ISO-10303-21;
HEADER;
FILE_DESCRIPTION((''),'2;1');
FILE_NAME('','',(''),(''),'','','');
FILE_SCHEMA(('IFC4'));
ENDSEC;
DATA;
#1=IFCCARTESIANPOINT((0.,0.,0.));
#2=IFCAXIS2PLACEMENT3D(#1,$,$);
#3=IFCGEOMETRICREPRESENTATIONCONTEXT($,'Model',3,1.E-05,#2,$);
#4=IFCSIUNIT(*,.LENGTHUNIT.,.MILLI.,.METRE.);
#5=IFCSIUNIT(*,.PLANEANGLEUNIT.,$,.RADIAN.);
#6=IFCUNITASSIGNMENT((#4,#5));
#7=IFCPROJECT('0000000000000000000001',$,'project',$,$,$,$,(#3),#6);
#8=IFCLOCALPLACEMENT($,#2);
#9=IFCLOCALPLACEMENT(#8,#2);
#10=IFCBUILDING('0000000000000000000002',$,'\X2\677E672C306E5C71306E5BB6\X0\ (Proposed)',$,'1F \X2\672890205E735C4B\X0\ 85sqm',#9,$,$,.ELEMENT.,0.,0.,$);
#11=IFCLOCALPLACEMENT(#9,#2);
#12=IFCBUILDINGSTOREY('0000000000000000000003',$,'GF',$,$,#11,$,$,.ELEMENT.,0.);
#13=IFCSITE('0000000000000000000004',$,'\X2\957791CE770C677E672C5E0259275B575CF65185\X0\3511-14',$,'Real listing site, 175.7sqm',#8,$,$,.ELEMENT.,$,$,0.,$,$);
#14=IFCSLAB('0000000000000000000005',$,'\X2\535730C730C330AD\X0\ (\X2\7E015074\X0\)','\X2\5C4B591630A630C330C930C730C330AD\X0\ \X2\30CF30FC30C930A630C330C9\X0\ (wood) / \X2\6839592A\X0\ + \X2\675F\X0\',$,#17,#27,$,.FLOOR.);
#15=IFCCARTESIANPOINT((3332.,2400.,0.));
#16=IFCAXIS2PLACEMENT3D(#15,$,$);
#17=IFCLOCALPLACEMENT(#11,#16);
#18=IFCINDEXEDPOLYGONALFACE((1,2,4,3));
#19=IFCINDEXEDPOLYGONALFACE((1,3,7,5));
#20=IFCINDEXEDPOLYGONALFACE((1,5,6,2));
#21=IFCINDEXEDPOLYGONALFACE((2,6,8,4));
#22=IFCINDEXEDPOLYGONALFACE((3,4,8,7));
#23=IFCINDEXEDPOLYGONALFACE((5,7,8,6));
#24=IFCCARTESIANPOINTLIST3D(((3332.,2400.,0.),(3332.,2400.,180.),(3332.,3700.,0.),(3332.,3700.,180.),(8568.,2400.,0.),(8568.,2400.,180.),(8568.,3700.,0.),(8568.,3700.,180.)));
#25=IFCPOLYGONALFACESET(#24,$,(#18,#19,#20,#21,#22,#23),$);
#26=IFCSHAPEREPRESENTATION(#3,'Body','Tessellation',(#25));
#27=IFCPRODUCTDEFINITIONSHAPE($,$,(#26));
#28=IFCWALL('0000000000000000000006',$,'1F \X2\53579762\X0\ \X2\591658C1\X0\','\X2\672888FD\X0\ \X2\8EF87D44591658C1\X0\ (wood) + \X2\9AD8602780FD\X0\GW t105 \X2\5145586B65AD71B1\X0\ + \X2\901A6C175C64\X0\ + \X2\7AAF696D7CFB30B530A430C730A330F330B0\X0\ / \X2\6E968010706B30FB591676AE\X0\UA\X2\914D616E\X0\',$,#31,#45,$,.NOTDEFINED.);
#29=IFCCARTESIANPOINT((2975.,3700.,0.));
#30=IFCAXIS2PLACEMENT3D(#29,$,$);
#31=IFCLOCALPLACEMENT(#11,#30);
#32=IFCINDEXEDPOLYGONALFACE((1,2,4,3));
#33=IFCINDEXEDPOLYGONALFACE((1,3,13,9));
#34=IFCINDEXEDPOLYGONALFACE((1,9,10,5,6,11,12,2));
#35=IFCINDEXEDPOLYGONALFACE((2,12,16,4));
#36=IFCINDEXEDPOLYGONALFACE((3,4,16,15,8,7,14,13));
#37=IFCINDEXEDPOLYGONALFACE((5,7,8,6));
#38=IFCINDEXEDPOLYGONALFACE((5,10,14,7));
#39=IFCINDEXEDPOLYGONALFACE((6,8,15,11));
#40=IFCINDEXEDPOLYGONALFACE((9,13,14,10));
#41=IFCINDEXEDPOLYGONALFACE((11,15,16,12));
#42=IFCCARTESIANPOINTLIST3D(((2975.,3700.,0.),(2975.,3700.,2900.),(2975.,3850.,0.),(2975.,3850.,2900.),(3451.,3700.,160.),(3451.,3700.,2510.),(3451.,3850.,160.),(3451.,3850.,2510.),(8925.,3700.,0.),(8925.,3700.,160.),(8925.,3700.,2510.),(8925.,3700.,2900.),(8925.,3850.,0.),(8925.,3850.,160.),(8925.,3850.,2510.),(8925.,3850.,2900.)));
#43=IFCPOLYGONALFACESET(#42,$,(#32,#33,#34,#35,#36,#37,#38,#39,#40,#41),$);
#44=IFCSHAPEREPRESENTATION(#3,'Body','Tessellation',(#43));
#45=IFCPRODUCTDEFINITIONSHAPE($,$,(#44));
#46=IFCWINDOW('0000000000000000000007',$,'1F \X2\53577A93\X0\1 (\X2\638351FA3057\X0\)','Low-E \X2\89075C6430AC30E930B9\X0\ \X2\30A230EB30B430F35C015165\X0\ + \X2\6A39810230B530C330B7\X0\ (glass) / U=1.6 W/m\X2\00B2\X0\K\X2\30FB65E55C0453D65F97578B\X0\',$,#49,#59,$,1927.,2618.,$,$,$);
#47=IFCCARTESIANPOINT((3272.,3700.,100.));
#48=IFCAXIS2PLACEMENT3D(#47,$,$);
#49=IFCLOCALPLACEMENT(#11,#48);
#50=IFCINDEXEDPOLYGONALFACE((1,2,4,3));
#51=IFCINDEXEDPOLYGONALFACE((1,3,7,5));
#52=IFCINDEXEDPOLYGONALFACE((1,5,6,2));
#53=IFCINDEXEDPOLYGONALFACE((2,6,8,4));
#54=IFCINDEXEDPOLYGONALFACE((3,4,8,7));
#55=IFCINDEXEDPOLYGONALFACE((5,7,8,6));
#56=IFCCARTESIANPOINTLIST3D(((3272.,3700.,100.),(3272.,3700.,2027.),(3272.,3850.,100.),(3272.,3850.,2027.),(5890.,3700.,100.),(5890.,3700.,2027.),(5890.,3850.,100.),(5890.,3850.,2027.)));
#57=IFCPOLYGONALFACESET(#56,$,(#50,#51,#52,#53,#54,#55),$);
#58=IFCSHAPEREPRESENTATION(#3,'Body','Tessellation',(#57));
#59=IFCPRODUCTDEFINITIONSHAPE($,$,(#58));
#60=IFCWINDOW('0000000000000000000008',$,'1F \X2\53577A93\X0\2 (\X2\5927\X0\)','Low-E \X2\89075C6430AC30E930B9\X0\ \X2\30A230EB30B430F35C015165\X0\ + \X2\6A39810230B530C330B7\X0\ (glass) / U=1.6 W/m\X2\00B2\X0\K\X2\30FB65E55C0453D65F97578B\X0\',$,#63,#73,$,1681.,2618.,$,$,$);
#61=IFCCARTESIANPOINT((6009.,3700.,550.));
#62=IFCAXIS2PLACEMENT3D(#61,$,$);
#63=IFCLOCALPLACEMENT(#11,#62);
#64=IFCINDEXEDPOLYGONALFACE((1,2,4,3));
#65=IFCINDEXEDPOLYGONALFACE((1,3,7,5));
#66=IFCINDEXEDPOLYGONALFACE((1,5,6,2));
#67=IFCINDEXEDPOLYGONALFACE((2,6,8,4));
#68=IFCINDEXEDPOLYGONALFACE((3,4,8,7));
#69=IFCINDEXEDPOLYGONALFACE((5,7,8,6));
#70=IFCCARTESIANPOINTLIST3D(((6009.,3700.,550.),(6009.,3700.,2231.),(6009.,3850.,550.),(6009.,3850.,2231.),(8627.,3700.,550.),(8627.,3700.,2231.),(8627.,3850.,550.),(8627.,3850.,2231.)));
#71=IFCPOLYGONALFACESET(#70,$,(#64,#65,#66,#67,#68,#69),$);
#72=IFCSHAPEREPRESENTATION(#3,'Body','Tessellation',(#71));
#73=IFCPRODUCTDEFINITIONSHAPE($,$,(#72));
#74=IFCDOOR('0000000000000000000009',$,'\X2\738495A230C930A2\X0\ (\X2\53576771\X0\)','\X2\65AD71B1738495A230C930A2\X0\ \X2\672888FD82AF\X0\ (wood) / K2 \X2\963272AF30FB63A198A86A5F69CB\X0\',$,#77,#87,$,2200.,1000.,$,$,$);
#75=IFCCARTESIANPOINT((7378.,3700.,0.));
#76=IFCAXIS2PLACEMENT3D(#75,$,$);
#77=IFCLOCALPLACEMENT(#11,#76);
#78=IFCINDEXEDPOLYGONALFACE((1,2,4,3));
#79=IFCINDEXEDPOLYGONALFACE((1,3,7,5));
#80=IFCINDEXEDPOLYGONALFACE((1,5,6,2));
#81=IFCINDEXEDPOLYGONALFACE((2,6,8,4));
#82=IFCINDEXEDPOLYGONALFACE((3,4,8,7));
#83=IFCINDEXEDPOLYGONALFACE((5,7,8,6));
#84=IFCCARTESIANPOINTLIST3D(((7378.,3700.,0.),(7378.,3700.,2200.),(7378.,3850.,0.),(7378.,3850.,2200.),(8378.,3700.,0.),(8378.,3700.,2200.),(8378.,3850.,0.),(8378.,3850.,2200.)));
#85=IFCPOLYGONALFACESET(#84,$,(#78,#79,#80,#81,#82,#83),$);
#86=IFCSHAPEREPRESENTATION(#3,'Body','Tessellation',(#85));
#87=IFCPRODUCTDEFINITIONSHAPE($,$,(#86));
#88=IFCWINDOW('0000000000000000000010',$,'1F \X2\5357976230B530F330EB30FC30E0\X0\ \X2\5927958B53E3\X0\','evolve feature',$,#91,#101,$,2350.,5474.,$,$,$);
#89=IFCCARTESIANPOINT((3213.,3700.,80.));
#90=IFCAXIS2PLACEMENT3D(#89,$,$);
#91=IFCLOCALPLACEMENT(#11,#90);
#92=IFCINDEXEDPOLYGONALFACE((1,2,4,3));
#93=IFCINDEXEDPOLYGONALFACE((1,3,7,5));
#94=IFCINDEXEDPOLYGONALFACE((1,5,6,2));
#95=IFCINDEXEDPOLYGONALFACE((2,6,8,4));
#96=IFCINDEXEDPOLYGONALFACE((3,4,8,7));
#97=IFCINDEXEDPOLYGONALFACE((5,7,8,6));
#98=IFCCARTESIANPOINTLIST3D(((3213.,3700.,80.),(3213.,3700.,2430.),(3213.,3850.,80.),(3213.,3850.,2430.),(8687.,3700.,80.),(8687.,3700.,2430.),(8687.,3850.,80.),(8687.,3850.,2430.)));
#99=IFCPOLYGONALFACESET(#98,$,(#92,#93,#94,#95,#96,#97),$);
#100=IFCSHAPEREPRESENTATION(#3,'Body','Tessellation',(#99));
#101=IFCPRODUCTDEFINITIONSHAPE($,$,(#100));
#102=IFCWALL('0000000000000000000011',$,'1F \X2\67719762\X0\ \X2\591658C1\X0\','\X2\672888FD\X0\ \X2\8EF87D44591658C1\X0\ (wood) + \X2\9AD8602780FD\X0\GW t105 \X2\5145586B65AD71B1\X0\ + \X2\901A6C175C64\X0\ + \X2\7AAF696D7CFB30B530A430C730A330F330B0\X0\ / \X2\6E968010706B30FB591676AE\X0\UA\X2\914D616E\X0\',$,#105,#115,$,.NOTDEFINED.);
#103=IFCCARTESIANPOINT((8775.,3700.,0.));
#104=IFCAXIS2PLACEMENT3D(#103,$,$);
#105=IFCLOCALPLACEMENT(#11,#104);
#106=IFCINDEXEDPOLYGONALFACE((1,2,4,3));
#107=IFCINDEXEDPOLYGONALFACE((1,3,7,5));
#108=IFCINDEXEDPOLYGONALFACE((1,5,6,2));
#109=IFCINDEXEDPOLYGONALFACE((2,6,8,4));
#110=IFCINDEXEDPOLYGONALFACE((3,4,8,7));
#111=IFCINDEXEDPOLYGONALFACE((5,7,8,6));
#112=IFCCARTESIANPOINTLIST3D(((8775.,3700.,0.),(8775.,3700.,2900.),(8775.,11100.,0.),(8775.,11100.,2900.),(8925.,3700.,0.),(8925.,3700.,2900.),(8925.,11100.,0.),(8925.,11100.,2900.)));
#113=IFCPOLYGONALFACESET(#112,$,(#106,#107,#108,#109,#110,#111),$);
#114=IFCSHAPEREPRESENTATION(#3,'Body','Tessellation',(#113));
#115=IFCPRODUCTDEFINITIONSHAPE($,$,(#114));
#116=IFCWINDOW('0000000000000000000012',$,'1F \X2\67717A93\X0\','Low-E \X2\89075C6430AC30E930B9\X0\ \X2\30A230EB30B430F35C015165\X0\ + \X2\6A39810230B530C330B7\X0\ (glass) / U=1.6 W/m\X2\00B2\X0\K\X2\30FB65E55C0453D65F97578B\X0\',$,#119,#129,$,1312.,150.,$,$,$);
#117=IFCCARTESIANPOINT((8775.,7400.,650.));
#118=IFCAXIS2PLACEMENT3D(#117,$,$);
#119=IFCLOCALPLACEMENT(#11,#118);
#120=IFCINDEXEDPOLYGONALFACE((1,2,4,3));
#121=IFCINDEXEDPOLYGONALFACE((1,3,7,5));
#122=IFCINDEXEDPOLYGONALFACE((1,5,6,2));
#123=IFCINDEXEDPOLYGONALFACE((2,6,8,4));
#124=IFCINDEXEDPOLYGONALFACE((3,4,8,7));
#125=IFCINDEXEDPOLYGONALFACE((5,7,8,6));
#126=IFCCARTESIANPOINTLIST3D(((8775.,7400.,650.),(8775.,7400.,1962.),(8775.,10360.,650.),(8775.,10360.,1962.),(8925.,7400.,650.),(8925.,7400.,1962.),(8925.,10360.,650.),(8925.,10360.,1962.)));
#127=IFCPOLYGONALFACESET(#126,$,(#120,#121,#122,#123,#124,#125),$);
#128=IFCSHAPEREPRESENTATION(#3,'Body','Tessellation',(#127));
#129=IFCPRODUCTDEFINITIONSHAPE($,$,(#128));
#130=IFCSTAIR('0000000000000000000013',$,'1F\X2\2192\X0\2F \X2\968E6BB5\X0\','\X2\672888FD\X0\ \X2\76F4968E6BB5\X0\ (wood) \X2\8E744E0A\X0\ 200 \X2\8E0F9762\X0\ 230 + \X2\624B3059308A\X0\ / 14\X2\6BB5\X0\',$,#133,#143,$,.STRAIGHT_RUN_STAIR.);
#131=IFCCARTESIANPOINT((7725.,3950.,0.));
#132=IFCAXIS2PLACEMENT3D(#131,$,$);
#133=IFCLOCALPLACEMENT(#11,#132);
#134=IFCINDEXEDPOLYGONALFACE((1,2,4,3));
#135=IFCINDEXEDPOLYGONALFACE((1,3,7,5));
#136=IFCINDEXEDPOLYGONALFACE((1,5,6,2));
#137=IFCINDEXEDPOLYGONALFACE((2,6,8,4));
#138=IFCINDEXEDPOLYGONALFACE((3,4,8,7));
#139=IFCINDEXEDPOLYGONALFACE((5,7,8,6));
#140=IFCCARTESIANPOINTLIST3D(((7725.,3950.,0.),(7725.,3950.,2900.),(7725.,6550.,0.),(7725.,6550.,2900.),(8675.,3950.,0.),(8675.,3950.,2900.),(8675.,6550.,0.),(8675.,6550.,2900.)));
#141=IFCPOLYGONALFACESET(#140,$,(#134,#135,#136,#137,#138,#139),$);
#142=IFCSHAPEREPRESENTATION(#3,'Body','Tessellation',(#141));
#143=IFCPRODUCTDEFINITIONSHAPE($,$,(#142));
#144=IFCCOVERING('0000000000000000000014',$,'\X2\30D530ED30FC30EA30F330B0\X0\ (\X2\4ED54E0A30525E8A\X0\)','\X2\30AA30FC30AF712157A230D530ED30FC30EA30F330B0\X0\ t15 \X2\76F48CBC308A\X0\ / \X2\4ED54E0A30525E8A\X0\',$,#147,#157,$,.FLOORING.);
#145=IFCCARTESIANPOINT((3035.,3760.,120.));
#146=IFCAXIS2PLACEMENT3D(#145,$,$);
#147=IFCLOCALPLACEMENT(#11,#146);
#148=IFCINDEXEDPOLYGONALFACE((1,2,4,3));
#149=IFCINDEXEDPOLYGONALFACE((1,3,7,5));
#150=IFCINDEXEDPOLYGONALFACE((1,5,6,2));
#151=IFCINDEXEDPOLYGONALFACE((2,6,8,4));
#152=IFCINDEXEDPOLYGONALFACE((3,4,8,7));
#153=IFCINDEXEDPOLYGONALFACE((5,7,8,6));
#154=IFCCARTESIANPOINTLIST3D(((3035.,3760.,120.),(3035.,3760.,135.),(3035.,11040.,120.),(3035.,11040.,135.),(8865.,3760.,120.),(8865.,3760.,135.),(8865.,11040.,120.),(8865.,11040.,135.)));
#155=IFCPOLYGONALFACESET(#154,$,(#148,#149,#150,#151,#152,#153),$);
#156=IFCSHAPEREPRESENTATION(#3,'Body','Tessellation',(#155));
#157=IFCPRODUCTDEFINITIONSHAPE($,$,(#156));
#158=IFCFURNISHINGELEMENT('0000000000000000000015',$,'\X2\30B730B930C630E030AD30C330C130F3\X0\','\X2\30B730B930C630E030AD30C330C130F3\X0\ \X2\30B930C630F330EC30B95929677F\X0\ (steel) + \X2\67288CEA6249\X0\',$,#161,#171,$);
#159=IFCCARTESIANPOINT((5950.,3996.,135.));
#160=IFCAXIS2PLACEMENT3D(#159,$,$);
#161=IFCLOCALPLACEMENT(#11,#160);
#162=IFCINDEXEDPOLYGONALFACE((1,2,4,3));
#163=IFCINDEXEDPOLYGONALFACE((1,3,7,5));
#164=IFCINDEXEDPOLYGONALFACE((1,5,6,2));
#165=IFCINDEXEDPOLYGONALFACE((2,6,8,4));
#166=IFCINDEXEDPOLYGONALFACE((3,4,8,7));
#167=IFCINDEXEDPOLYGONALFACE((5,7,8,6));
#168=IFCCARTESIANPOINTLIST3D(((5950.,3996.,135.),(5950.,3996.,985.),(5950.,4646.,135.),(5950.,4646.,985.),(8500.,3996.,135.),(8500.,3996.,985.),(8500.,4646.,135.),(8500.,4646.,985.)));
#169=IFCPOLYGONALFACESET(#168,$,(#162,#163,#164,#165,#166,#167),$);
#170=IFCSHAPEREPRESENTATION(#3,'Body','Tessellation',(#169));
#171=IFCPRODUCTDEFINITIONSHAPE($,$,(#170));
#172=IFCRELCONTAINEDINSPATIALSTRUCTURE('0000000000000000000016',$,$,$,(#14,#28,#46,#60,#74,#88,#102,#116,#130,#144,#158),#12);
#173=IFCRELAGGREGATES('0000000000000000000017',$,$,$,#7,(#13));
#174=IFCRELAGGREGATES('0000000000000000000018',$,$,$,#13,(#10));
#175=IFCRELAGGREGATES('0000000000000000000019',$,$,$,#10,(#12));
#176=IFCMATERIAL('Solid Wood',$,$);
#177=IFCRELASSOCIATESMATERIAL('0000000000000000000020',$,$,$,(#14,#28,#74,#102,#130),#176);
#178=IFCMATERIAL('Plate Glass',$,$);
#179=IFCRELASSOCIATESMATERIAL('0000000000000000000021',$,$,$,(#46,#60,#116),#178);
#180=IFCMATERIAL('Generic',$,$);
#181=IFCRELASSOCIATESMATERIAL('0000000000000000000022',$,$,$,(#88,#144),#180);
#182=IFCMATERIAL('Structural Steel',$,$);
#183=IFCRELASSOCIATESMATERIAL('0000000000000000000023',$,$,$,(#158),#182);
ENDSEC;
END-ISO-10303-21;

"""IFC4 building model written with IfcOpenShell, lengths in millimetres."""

from ifc_helpers import new_model, si_unit, frame, frame_2d, origin, place, context, project, spatial, rectangle, extrude, material, element, fill, save


model = new_model("IFC4")

# Units and contexts
model_context = context("Model", 3, precision=1e-05, world=origin())
ifc_project = project(units=[si_unit("LENGTHUNIT", "METRE", prefix="MILLI"), si_unit("PLANEANGLEUNIT", "RADIAN")], contexts=[model_context])

# Site, building, storey
site_placement = place(None, origin())
site = spatial("IfcSite", under=ifc_project, at=site_placement, Name="長野県松本市大字島内3511-14", ObjectType="Real listing site, 175.7sqm", CompositionType="ELEMENT", RefElevation=0.0)
building_placement = place(site_placement, origin())
building = spatial("IfcBuilding", under=site, at=building_placement, Name="松本の山の家 (Proposed)", ObjectType="1F 木造平屋 85sqm", CompositionType="ELEMENT", ElevationOfRefHeight=0.0, ElevationOfTerrain=0.0)
storey_placement = place(building_placement, origin())
storey = spatial("IfcBuildingStorey", under=building, at=storey_placement, Name="GF", CompositionType="ELEMENT", Elevation=0.0)

# Slab
ifc_material_1 = material(Name="Solid Wood")
slab_1_placement = place(storey_placement, frame((3332.0, 2400.0, 0.0)))
element("IfcSlab", 1, at=slab_1_placement, inside=storey, material=ifc_material_1, Name="南デッキ (縁側)", Description="屋外ウッドデッキ ハードウッド (wood) / 根太 + 束", PredefinedType="FLOOR", context=model_context, shape_type="SweptSolid", body=[
    extrude(rectangle(XDim=5236.0, YDim=1300.0, at=frame_2d((2618.0, 650.0))), frame((3332.0, 2400.0, 0.0)), (0.0, 0.0, 1.0), 180.0),
])
ifc_material_2 = material(Name="Generic")

# Wall, openings, windows, door
wall_1_placement = place(storey_placement, frame((2975.0, 3700.0, 0.0)))
wall_1 = element("IfcWall", 2, at=wall_1_placement, inside=storey, material=ifc_material_1, Name="1F 南面 外壁", Description="木製 軸組外壁 (wood) + 高性能GW t105 充填断熱 + 通気層 + 窯業系サイディング / 準耐火・外皮UA配慮", PredefinedType="NOTDEFINED", context=model_context, shape_type="SweptSolid", body=[
    extrude(rectangle(XDim=5950.0, YDim=150.0, at=frame_2d((2975.0, 75.0))), frame((2975.0, 3700.0, 0.0)), (0.0, 0.0, 1.0), 2900.0),
])
opening_1_placement = place(storey_placement, frame((3272.0, 3700.0, 100.0)))
opening_1 = element("IfcOpeningElement", 3, at=opening_1_placement, cuts=wall_1, PredefinedType="NOTDEFINED", context=model_context, shape_type="SweptSolid", body=[
    extrude(rectangle(XDim=2618.0, YDim=150.0, at=frame_2d((1309.0, 75.0))), frame((3272.0, 3700.0, 100.0)), (0.0, 0.0, 1.0), 1927.0),
])
opening_2_placement = place(storey_placement, frame((6009.0, 3700.0, 550.0)))
opening_2 = element("IfcOpeningElement", 4, at=opening_2_placement, cuts=wall_1, PredefinedType="NOTDEFINED", context=model_context, shape_type="SweptSolid", body=[
    extrude(rectangle(XDim=2618.0, YDim=150.0, at=frame_2d((1309.0, 75.0))), frame((6009.0, 3700.0, 550.0)), (0.0, 0.0, 1.0), 1681.0),
])
opening_3_placement = place(storey_placement, frame((7378.0, 3700.0, 0.0)))
opening_3 = element("IfcOpeningElement", 5, at=opening_3_placement, cuts=wall_1, PredefinedType="NOTDEFINED", context=model_context, shape_type="SweptSolid", body=[
    extrude(rectangle(XDim=1000.0, YDim=150.0, at=frame_2d((500.0, 75.0))), frame((7378.0, 3700.0, 0.0)), (0.0, 0.0, 1.0), 2200.0),
])
opening_4_placement = place(storey_placement, frame((3213.0, 3700.0, 80.0)))
opening_4 = element("IfcOpeningElement", 6, at=opening_4_placement, cuts=wall_1, PredefinedType="NOTDEFINED", context=model_context, shape_type="SweptSolid", body=[
    extrude(rectangle(XDim=5474.0, YDim=150.0, at=frame_2d((2737.0, 75.0))), frame((3213.0, 3700.0, 80.0)), (0.0, 0.0, 1.0), 2350.0),
])
ifc_material_3 = material(Name="Plate Glass")
window_1_placement = place(storey_placement, frame((3272.0, 3700.0, 100.0)))
window_1 = element("IfcWindow", 7, at=window_1_placement, inside=storey, material=ifc_material_3, Name="1F 南窓1 (掃出し)", Description="Low-E 複層ガラス アルゴン封入 + 樹脂サッシ (glass) / U=1.6 W/m²K・日射取得型", OverallHeight=1927.0, OverallWidth=2618.0, context=model_context, shape_type="SweptSolid", body=[
    extrude(rectangle(XDim=2618.0, YDim=150.0, at=frame_2d((1309.0, 75.0))), frame((3272.0, 3700.0, 100.0)), (0.0, 0.0, 1.0), 1927.0),
])
fill(opening_1, window_1)
window_2_placement = place(storey_placement, frame((6009.0, 3700.0, 550.0)))
window_2 = element("IfcWindow", 8, at=window_2_placement, inside=storey, material=ifc_material_3, Name="1F 南窓2 (大)", Description="Low-E 複層ガラス アルゴン封入 + 樹脂サッシ (glass) / U=1.6 W/m²K・日射取得型", OverallHeight=1681.0, OverallWidth=2618.0, context=model_context, shape_type="SweptSolid", body=[
    extrude(rectangle(XDim=2618.0, YDim=150.0, at=frame_2d((1309.0, 75.0))), frame((6009.0, 3700.0, 550.0)), (0.0, 0.0, 1.0), 1681.0),
])
fill(opening_2, window_2)
door_placement = place(storey_placement, frame((7378.0, 3700.0, 0.0)))
door = element("IfcDoor", 9, at=door_placement, inside=storey, material=ifc_material_1, Name="玄関ドア (南東)", Description="断熱玄関ドア 木製芯 (wood) / K2 防犯・採風機構", OverallHeight=2200.0, OverallWidth=1000.0, context=model_context, shape_type="SweptSolid", body=[
    extrude(rectangle(XDim=1000.0, YDim=150.0, at=frame_2d((500.0, 75.0))), frame((7378.0, 3700.0, 0.0)), (0.0, 0.0, 1.0), 2200.0),
])
fill(opening_3, door)
window_3_placement = place(storey_placement, frame((3213.0, 3700.0, 80.0)))
window_3 = element("IfcWindow", 10, at=window_3_placement, inside=storey, material=ifc_material_2, Name="1F 南面サンルーム 大開口", Description="evolve feature", OverallHeight=2350.0, OverallWidth=5474.0, context=model_context, shape_type="SweptSolid", body=[
    extrude(rectangle(XDim=5474.0, YDim=150.0, at=frame_2d((2737.0, 75.0))), frame((3213.0, 3700.0, 80.0)), (0.0, 0.0, 1.0), 2350.0),
])
fill(opening_4, window_3)

# Wall, opening, window
wall_2_placement = place(storey_placement, frame((8775.0, 3700.0, 0.0)))
wall_2 = element("IfcWall", 11, at=wall_2_placement, inside=storey, material=ifc_material_1, Name="1F 東面 外壁", Description="木製 軸組外壁 (wood) + 高性能GW t105 充填断熱 + 通気層 + 窯業系サイディング / 準耐火・外皮UA配慮", PredefinedType="NOTDEFINED", context=model_context, shape_type="SweptSolid", body=[
    extrude(rectangle(XDim=150.0, YDim=7400.0, at=frame_2d((75.0, 3700.0))), frame((8775.0, 3700.0, 0.0)), (0.0, 0.0, 1.0), 2900.0),
])
opening_5_placement = place(storey_placement, frame((8775.0, 7400.0, 650.0)))
opening_5 = element("IfcOpeningElement", 12, at=opening_5_placement, cuts=wall_2, PredefinedType="NOTDEFINED", context=model_context, shape_type="SweptSolid", body=[
    extrude(rectangle(XDim=150.0, YDim=2960.0, at=frame_2d((75.0, 1480.0))), frame((8775.0, 7400.0, 650.0)), (0.0, 0.0, 1.0), 1312.0),
])
window_4_placement = place(storey_placement, frame((8775.0, 7400.0, 650.0)))
window_4 = element("IfcWindow", 13, at=window_4_placement, inside=storey, material=ifc_material_3, Name="1F 東窓", Description="Low-E 複層ガラス アルゴン封入 + 樹脂サッシ (glass) / U=1.6 W/m²K・日射取得型", OverallHeight=1312.0, OverallWidth=150.0, context=model_context, shape_type="SweptSolid", body=[
    extrude(rectangle(XDim=150.0, YDim=2960.0, at=frame_2d((75.0, 1480.0))), frame((8775.0, 7400.0, 650.0)), (0.0, 0.0, 1.0), 1312.0),
])
fill(opening_5, window_4)

# Stair
stair_placement = place(storey_placement, frame((7725.0, 3950.0, 0.0)))
element("IfcStair", 14, at=stair_placement, inside=storey, material=ifc_material_1, Name="1F→2F 階段", Description="木製 直階段 (wood) 蹴上 200 踏面 230 + 手すり / 14段", PredefinedType="STRAIGHT_RUN_STAIR", context=model_context, shape_type="SweptSolid", body=[
    extrude(rectangle(XDim=950.0, YDim=2600.0, at=frame_2d((475.0, 1300.0))), frame((7725.0, 3950.0, 0.0)), (0.0, 0.0, 1.0), 2900.0),
])

# Covering
covering_placement = place(storey_placement, frame((3035.0, 3760.0, 120.0)))
element("IfcCovering", 15, at=covering_placement, inside=storey, material=ifc_material_2, Name="フローリング (仕上げ床)", Description="オーク無垢フローリング t15 直貼り / 仕上げ床", PredefinedType="FLOORING", context=model_context, shape_type="SweptSolid", body=[
    extrude(rectangle(XDim=5830.0, YDim=7280.0, at=frame_2d((2915.0, 3640.0))), frame((3035.0, 3760.0, 120.0)), (0.0, 0.0, 1.0), 15.0),
])

# Furnishing element
ifc_material_4 = material(Name="Structural Steel")
furnishing_placement = place(storey_placement, frame((5950.0, 3996.0, 135.0)))
element("IfcFurnishingElement", 16, at=furnishing_placement, inside=storey, material=ifc_material_4, Name="システムキッチン", Description="システムキッチン ステンレス天板 (steel) + 木質扉", context=model_context, shape_type="SweptSolid", body=[
    extrude(rectangle(XDim=2550.0, YDim=650.0, at=frame_2d((1275.0, 325.0))), frame((5950.0, 3996.0, 135.0)), (0.0, 0.0, 1.0), 850.0),
])

save(model, "model.ifc")
